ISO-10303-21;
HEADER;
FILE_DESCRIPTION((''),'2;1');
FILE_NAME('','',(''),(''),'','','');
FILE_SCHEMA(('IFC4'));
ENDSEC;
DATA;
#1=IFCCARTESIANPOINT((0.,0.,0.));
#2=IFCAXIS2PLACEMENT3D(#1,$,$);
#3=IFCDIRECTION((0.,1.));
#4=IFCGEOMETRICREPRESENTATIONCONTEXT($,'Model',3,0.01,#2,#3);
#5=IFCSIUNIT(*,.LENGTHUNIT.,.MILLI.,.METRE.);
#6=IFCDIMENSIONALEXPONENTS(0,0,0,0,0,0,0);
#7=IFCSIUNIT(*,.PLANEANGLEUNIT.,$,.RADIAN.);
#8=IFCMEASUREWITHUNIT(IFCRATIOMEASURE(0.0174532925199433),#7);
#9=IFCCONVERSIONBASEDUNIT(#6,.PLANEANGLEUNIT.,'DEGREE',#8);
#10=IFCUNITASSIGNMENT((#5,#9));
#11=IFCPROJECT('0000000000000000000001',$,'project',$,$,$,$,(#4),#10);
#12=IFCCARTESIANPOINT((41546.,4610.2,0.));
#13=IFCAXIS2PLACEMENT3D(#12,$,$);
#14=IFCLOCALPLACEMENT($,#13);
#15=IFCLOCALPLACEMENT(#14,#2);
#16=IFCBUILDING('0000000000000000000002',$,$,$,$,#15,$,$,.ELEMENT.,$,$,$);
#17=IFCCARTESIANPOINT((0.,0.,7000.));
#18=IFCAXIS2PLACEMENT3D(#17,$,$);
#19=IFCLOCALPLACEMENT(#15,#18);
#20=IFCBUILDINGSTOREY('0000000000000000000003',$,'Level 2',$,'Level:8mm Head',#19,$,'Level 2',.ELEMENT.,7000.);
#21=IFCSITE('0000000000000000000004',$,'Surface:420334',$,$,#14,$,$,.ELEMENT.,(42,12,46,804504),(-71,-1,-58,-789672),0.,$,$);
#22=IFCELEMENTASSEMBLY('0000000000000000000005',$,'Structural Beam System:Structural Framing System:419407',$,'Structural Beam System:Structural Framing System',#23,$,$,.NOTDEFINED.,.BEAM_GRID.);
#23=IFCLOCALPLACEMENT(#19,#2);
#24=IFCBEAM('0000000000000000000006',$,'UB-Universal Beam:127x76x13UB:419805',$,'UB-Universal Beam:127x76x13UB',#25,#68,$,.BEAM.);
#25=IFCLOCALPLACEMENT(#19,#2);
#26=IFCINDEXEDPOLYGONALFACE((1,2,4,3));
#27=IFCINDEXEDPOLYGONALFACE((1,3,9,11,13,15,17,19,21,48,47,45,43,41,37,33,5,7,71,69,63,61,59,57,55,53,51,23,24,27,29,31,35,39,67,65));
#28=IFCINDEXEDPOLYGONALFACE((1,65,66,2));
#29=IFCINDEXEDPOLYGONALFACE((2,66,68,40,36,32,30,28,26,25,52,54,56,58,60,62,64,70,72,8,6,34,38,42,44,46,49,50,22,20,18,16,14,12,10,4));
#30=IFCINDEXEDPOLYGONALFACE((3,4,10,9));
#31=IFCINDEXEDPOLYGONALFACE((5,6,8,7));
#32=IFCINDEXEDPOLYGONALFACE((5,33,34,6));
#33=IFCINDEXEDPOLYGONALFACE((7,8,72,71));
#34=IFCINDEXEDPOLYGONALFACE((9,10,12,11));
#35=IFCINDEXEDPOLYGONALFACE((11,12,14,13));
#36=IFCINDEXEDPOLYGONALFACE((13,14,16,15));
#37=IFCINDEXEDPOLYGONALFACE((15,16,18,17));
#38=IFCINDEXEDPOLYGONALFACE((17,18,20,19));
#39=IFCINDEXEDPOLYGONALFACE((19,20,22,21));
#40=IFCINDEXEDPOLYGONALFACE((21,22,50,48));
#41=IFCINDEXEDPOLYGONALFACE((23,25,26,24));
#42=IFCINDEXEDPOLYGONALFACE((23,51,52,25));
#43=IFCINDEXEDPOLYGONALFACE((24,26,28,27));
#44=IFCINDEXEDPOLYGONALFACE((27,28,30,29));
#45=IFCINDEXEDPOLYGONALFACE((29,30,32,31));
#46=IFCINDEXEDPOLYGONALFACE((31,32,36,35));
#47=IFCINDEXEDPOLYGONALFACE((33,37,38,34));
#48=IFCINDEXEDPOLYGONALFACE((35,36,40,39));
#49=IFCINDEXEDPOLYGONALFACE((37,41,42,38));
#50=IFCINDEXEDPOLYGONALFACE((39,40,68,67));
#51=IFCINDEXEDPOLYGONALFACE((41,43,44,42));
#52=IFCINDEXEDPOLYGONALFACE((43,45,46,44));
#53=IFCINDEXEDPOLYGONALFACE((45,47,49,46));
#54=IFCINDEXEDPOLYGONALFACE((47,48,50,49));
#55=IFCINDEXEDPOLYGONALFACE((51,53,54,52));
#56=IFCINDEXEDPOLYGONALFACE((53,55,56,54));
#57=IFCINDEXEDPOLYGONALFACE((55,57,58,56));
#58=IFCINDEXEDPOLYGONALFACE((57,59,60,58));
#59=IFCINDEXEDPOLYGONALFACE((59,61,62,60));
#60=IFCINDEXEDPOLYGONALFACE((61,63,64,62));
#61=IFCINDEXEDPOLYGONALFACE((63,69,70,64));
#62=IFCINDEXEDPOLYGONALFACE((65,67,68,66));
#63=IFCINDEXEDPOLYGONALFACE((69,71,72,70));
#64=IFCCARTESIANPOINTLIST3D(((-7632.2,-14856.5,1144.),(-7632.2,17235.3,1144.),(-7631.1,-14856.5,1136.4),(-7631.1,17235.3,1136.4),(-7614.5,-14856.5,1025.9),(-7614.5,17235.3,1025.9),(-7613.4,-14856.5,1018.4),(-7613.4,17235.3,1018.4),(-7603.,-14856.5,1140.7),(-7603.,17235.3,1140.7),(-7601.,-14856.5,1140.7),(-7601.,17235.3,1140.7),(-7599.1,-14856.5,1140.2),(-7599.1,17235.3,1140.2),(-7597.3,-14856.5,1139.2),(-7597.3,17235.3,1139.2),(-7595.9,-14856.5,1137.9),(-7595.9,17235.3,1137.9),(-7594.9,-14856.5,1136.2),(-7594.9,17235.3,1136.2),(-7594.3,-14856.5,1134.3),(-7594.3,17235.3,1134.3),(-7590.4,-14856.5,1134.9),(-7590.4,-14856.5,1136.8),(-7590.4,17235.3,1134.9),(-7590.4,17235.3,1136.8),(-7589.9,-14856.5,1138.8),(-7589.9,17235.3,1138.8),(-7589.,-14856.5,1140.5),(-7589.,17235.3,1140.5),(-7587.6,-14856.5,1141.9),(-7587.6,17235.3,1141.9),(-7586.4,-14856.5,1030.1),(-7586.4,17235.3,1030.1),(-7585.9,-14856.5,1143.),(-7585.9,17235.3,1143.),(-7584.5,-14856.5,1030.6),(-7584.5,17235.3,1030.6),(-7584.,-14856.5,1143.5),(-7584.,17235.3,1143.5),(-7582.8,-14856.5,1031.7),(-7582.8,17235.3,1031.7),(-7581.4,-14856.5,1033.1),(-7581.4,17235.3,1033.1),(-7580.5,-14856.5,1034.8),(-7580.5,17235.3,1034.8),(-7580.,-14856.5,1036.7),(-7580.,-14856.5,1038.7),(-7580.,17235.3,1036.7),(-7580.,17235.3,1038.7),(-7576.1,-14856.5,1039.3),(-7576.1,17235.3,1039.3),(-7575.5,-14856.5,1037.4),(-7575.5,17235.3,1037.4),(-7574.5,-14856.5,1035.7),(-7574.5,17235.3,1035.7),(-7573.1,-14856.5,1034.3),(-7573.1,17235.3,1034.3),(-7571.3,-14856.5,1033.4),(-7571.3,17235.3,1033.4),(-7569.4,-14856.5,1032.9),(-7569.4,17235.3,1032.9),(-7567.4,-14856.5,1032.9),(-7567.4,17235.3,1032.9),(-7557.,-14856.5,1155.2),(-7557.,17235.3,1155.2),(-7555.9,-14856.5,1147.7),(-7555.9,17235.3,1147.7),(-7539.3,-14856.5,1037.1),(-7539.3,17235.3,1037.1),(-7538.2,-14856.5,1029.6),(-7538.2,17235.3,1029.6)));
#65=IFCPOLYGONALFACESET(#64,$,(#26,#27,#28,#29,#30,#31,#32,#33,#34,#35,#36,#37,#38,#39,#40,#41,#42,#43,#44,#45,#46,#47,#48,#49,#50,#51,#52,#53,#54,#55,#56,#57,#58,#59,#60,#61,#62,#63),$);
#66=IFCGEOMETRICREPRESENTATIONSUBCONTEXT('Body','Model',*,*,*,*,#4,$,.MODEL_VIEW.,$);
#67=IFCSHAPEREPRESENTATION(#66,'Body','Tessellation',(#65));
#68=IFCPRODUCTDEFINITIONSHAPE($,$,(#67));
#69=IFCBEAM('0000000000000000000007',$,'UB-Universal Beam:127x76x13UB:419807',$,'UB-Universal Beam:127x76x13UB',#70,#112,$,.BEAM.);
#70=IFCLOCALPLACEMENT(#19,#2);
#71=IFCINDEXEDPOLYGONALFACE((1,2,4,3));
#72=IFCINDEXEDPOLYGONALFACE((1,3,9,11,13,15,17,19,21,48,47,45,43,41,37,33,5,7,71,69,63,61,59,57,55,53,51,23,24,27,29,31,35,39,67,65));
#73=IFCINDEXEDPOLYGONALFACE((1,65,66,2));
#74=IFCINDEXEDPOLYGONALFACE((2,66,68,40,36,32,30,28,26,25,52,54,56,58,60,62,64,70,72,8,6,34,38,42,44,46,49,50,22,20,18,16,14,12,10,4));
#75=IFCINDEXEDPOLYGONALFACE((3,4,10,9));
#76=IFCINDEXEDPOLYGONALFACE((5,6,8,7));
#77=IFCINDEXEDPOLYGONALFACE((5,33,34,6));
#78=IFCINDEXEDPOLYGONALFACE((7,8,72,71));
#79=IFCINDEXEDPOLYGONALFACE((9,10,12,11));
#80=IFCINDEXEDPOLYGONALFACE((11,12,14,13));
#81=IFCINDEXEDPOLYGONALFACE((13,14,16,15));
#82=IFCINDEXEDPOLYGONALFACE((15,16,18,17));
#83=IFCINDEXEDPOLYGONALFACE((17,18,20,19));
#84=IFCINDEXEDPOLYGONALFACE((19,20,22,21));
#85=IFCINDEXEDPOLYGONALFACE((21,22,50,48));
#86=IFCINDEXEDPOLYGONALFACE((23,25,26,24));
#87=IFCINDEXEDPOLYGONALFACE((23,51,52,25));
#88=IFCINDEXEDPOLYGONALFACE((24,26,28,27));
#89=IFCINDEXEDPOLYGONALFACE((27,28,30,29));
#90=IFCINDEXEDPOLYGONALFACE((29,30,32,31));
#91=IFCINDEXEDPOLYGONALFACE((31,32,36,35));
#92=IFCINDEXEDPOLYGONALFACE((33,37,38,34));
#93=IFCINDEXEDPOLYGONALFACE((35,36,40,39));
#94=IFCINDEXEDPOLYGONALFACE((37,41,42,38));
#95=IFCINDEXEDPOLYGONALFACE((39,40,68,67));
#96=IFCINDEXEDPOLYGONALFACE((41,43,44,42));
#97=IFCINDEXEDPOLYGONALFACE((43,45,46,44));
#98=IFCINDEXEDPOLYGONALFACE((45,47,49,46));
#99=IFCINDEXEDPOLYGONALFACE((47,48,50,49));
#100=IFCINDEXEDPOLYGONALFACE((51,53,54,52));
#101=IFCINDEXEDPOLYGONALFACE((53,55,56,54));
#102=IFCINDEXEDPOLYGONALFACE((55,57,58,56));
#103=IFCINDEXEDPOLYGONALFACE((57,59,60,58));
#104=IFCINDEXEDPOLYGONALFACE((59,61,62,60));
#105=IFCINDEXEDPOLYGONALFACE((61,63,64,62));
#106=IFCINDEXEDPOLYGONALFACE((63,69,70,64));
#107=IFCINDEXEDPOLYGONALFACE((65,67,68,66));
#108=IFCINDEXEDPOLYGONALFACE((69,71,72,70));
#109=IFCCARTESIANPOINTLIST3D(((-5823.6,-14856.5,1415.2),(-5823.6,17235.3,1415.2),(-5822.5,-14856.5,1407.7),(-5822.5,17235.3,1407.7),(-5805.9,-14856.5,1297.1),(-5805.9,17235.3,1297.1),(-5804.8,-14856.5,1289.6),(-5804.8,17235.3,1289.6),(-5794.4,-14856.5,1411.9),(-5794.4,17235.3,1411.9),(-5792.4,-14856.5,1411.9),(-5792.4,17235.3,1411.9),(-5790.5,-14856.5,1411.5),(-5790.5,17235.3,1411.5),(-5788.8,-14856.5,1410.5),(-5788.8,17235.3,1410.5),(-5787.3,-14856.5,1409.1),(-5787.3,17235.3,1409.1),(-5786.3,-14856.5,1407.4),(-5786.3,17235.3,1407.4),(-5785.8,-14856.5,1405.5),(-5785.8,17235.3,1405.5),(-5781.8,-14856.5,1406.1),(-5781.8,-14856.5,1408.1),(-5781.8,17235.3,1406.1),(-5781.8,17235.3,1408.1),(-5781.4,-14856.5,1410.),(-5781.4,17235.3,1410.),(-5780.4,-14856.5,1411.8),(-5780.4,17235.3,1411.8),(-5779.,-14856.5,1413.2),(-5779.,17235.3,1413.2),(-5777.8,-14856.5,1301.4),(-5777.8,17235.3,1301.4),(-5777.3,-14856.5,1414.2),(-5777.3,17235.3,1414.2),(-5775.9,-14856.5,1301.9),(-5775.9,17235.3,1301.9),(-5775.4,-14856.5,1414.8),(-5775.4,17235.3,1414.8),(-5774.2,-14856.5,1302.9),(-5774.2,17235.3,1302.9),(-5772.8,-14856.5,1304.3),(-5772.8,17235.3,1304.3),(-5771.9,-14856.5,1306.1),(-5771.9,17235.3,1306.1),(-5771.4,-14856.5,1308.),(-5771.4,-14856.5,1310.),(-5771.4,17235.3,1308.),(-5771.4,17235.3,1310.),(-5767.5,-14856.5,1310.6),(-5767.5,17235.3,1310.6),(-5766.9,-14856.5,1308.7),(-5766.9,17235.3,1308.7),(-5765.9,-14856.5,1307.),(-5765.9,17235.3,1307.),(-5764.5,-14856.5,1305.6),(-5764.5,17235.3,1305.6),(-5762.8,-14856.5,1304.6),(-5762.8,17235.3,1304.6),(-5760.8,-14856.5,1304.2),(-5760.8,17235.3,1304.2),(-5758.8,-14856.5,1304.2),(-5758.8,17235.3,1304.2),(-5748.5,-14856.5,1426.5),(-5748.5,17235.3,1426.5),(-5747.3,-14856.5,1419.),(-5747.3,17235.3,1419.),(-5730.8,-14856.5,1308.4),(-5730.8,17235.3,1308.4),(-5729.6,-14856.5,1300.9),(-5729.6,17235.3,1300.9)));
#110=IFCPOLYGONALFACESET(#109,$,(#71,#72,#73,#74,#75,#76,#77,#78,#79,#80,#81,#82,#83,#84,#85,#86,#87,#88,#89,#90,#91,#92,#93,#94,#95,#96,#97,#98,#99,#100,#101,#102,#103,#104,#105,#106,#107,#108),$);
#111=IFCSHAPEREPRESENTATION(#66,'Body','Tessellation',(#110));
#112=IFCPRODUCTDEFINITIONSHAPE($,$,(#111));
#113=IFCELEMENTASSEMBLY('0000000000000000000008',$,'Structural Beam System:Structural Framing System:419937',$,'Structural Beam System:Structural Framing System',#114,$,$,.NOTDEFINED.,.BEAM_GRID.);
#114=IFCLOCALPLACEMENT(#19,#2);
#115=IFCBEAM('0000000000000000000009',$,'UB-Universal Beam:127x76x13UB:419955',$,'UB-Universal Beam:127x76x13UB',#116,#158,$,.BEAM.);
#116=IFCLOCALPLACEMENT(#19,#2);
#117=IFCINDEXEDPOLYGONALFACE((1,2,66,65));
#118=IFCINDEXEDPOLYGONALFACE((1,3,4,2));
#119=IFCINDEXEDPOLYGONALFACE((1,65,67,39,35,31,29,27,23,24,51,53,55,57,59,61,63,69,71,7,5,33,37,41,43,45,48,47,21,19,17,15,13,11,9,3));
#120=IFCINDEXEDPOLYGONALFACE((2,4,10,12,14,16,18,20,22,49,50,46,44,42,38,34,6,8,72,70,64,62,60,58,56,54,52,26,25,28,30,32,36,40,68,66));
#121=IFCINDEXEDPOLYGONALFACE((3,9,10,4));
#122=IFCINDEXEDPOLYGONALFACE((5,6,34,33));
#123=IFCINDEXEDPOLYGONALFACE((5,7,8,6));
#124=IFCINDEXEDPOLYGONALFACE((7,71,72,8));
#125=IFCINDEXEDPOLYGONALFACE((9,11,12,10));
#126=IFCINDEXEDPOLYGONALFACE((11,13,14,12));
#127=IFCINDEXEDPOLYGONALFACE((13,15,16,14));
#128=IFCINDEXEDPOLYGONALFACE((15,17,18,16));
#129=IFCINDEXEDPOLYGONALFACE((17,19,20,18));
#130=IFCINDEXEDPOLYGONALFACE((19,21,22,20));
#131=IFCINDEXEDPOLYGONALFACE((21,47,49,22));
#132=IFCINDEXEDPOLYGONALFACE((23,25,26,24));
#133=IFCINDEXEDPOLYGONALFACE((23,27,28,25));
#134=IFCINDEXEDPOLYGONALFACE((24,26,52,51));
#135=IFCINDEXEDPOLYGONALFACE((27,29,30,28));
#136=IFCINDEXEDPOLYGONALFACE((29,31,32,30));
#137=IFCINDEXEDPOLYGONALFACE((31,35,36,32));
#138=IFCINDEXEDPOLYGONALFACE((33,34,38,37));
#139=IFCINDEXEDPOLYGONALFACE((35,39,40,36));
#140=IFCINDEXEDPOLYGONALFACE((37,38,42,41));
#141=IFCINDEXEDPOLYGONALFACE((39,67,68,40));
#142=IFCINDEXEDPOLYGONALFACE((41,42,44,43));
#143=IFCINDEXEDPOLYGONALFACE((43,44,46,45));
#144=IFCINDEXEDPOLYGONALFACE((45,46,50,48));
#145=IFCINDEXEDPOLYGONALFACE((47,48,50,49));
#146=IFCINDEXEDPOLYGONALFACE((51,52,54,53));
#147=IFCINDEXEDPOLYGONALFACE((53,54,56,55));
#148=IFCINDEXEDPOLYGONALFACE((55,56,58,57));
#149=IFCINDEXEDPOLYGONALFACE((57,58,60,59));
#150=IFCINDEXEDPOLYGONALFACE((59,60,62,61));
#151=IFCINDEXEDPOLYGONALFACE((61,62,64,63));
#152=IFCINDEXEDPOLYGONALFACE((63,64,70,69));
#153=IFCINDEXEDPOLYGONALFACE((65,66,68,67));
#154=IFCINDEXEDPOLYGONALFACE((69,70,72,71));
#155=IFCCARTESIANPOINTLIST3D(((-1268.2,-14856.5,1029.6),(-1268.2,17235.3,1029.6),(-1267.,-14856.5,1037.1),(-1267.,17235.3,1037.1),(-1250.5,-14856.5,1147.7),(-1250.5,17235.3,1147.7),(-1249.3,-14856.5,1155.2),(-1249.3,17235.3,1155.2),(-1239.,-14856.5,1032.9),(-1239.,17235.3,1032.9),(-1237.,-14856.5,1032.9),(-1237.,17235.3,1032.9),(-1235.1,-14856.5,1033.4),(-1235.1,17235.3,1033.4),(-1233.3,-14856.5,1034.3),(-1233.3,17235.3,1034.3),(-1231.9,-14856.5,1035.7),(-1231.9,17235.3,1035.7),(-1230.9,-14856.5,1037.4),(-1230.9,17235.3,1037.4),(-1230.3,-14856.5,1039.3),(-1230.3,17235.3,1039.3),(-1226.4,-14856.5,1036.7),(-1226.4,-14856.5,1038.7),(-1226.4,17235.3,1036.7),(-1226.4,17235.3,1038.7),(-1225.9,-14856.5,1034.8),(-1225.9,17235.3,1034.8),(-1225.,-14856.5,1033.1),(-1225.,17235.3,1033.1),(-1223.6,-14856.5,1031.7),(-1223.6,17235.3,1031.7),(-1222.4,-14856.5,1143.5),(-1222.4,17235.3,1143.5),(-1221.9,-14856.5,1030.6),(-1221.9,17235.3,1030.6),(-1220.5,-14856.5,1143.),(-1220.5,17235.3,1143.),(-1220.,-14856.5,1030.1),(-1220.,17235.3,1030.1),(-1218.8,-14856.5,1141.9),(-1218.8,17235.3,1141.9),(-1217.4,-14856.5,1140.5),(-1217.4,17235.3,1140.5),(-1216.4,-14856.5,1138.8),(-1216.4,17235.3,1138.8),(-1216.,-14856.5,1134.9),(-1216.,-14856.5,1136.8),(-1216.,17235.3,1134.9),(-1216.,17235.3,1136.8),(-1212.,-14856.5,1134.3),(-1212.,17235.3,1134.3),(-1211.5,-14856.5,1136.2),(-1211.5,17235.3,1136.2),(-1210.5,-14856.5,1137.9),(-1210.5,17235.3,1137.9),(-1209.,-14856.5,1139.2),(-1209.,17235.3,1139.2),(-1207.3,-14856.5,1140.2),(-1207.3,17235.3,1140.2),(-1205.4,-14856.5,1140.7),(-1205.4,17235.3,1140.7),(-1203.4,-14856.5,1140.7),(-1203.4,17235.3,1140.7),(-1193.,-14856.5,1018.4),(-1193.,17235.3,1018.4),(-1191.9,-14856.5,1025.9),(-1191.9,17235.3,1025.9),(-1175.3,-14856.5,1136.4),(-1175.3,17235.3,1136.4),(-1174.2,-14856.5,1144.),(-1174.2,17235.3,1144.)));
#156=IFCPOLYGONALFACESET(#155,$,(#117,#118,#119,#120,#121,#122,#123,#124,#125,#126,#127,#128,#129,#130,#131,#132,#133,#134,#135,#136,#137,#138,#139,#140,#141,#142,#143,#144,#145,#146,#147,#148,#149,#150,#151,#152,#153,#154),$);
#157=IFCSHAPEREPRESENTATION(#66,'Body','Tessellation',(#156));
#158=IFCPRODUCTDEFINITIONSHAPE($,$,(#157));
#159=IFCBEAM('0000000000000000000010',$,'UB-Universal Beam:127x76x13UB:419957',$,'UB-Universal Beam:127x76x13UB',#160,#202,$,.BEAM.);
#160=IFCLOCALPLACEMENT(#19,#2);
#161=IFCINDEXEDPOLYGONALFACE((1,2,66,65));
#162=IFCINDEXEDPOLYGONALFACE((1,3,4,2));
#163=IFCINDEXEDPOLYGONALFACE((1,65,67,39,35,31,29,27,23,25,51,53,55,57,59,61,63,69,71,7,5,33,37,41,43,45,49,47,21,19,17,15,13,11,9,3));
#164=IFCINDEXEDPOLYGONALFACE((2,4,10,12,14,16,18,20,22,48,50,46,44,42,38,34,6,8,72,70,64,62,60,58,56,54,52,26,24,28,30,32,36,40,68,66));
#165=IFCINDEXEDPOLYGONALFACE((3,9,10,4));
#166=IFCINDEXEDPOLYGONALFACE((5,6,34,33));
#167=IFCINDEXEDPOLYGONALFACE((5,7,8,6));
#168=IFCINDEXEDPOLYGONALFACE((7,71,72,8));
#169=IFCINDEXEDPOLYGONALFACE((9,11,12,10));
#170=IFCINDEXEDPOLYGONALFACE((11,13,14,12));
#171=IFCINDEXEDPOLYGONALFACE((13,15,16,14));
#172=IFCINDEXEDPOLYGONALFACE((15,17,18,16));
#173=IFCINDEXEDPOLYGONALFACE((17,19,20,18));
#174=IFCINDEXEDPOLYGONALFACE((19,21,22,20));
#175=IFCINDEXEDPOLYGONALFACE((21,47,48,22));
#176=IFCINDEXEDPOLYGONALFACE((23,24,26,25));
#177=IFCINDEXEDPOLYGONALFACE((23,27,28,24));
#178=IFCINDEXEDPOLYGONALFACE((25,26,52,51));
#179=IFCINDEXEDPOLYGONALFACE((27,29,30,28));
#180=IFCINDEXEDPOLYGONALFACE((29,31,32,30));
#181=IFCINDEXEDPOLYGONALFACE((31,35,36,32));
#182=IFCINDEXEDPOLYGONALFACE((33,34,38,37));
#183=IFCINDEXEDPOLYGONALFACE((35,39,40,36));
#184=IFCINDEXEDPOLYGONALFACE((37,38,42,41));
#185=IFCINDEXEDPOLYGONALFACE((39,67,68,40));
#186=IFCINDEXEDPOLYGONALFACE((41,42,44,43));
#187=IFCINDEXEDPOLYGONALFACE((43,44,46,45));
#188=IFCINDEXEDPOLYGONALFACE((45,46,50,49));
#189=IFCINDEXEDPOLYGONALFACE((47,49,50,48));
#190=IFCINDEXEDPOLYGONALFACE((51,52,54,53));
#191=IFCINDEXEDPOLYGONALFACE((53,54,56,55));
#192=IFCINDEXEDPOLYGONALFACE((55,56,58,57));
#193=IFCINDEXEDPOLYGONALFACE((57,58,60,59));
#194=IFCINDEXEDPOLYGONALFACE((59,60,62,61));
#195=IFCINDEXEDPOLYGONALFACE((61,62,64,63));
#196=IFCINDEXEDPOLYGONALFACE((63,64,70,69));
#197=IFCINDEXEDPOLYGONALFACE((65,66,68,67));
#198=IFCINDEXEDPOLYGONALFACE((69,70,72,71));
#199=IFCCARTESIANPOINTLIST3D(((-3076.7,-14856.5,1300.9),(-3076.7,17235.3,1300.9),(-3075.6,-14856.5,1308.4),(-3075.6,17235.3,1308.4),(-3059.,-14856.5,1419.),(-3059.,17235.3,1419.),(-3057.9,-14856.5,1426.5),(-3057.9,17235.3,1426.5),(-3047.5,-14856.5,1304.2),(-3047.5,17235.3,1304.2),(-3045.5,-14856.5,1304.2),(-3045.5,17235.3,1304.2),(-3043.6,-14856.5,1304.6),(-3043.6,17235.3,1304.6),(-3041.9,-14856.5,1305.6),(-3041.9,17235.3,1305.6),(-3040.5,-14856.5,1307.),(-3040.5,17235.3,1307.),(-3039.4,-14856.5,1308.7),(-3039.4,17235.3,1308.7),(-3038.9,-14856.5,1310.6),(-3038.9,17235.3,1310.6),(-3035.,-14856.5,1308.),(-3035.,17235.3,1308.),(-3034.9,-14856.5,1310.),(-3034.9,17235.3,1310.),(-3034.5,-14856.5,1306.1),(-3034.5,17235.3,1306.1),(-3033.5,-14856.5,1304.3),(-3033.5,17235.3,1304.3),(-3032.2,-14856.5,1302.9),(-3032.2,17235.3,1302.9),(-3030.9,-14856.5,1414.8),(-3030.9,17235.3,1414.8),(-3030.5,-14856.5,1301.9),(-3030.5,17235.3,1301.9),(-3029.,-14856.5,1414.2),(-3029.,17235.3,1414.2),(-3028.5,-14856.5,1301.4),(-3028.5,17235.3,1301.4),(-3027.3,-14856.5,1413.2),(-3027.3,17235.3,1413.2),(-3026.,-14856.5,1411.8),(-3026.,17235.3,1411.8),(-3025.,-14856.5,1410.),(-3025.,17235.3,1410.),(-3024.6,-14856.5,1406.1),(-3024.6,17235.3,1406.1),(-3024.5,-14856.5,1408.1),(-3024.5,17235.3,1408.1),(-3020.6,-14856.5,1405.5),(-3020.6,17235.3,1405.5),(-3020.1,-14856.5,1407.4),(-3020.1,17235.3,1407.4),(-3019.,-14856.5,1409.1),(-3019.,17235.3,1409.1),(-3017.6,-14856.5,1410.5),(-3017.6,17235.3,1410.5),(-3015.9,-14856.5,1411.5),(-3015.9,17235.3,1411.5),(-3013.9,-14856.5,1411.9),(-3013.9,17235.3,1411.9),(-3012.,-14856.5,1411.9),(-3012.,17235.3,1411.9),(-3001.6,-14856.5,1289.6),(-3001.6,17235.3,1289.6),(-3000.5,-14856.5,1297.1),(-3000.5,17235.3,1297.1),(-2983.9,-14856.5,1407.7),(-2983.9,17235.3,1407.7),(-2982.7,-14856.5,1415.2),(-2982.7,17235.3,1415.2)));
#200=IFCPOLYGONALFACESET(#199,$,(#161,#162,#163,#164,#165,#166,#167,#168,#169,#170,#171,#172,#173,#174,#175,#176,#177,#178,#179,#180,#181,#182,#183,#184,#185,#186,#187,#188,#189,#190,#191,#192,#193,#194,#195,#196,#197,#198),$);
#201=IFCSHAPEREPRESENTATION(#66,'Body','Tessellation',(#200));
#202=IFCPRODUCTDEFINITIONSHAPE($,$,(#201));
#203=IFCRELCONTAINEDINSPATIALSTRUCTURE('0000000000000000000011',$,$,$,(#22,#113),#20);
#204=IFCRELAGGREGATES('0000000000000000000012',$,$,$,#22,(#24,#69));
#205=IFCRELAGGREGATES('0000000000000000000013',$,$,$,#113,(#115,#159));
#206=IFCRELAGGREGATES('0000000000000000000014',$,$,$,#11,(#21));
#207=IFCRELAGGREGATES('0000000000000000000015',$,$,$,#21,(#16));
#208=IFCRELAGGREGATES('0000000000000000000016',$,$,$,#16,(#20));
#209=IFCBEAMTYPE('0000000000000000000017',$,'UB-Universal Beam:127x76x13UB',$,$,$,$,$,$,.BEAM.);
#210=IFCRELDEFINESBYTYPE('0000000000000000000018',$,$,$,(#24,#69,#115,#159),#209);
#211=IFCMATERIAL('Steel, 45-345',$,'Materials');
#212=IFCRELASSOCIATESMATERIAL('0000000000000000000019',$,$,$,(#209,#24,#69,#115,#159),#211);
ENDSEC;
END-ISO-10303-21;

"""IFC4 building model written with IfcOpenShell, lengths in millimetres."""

from ifc_helpers import new_model, entity, si_unit, converted_unit, direction, frame, frame_2d, origin, place, context, subcontext, project, spatial, i_section, extrude, source, transform, mapped, material, material_profile, profile_set, profile_usage, type_object, type_shapes, element, aggregate, save


model = new_model("IFC4")

# Units and contexts
model_context = context("Model", 3, precision=0.01, world=origin(), true_north=direction((0.0, 1.0)))
body_context = subcontext(model_context, "Body", "Model", "MODEL_VIEW")
ifc_project = project(units=[si_unit("LENGTHUNIT", "METRE", prefix="MILLI"), converted_unit("PLANEANGLEUNIT", "DEGREE", entity("IfcRatioMeasure", 0.0174532925199433), si_unit("PLANEANGLEUNIT", "RADIAN"), dimensions=[0, 0, 0, 0, 0, 0, 0])], contexts=[model_context])

# Site, building, storey
site_placement = place(None, frame((41546.0, 4610.2, 0.0)))
site = spatial("IfcSite", under=ifc_project, at=site_placement, Name="Surface:420334", CompositionType="ELEMENT", RefLatitude=(42, 12, 46, 804504), RefLongitude=(-71, -1, -58, -789672), RefElevation=0.0)
building_placement = place(site_placement, origin())
building = spatial("IfcBuilding", under=site, at=building_placement, CompositionType="ELEMENT")
storey_placement = place(building_placement, frame((0.0, 0.0, 7000.0)))
storey = spatial("IfcBuildingStorey", under=building, at=storey_placement, Name="Level 2", ObjectType="Level:8mm Head", LongName="Level 2", CompositionType="ELEMENT", Elevation=7000.0)

# Element assemblies, beams
assembly_1_placement = place(storey_placement, origin())
assembly_1 = element("IfcElementAssembly", 1, at=assembly_1_placement, inside=storey, Name="Structural Beam System:Structural Framing System:419407", ObjectType="Structural Beam System:Structural Framing System", AssemblyPlace="NOTDEFINED", PredefinedType="BEAM_GRID")
ifc_material_1 = material(Name="Steel, 45-345", Category="Materials")
ifc_material_profile = material_profile(ifc_material_1, i_section(OverallWidth=76.0, OverallDepth=127.0, WebThickness=4.0, FlangeThickness=7.6, FilletRadius=7.6, at=frame_2d((0.0, 0.0), x_axis=(0.0, 1.0))), Name="127x76x13UB")
ifc_profile_set = profile_set([ifc_material_profile], Name="127x76x13UB")
ifc_profile_usage_1 = profile_usage(ifc_profile_set, cardinal=8)
beam_type = type_object("IfcBeamType", Name="UB-Universal Beam:127x76x13UB", PredefinedType="BEAM", material=ifc_profile_set)
shared_shape = source(origin(), body_context, "Body", "SweptSolid", [
    extrude(i_section(OverallWidth=76.0, OverallDepth=127.0, WebThickness=4.0, FlangeThickness=7.6, FilletRadius=7.6, at=frame_2d((0.0, 0.0), x_axis=(0.0, 1.0))), frame((-15973.5, 0.0, 0.0), z_axis=(1.0, 0.0, 0.0), x_axis=(0.0, 0.0, -1.0)), (0.0, 0.0, 1.0), 32091.8),
])
type_shapes(beam_type, [shared_shape])
beam_1_placement = place(assembly_1_placement, frame((-7585.2, 1261.8, 1086.8), z_axis=(-0.148327, 0.0, 0.988938), x_axis=(0.0, -1.0, 0.0)))
beam_1 = element("IfcBeam", 2, at=beam_1_placement, type_object=beam_type, material=ifc_profile_usage_1, Name="UB-Universal Beam:127x76x13UB:419805", ObjectType="UB-Universal Beam:127x76x13UB", PredefinedType="BEAM", context=body_context, shape_type="MappedRepresentation", body=[
    mapped(shared_shape, transform((0.0, 0.0, 0.0), scale=1.0)),
])
ifc_profile_usage_2 = profile_usage(ifc_profile_set, cardinal=8)
beam_2_placement = place(assembly_1_placement, frame((-5776.6, 1261.8, 1358.1), z_axis=(-0.148327, 0.0, 0.988938), x_axis=(0.0, -1.0, 0.0)))
beam_2 = element("IfcBeam", 3, at=beam_2_placement, type_object=beam_type, material=ifc_profile_usage_2, Name="UB-Universal Beam:127x76x13UB:419807", ObjectType="UB-Universal Beam:127x76x13UB", PredefinedType="BEAM", context=body_context, shape_type="MappedRepresentation", body=[
    mapped(shared_shape, transform((0.0, 0.0, 0.0), scale=1.0)),
])
aggregate(assembly_1, [beam_1, beam_2])
assembly_2_placement = place(storey_placement, origin())
assembly_2 = element("IfcElementAssembly", 4, at=assembly_2_placement, inside=storey, Name="Structural Beam System:Structural Framing System:419937", ObjectType="Structural Beam System:Structural Framing System", AssemblyPlace="NOTDEFINED", PredefinedType="BEAM_GRID")
ifc_profile_usage_3 = profile_usage(ifc_profile_set, cardinal=8)
beam_3_placement = place(assembly_2_placement, frame((-1221.2, 1261.8, 1086.8), z_axis=(0.148327, 0.0, 0.988938), x_axis=(0.0, -1.0, 0.0)))
beam_3 = element("IfcBeam", 5, at=beam_3_placement, type_object=beam_type, material=ifc_profile_usage_3, Name="UB-Universal Beam:127x76x13UB:419955", ObjectType="UB-Universal Beam:127x76x13UB", PredefinedType="BEAM", context=body_context, shape_type="MappedRepresentation", body=[
    mapped(shared_shape, transform((0.0, 0.0, 0.0), scale=1.0)),
])
ifc_profile_usage_4 = profile_usage(ifc_profile_set, cardinal=8)
beam_4_placement = place(assembly_2_placement, frame((-3029.7, 1261.8, 1358.1), z_axis=(0.148327, 0.0, 0.988938), x_axis=(0.0, -1.0, 0.0)))
beam_4 = element("IfcBeam", 6, at=beam_4_placement, type_object=beam_type, material=ifc_profile_usage_4, Name="UB-Universal Beam:127x76x13UB:419957", ObjectType="UB-Universal Beam:127x76x13UB", PredefinedType="BEAM", context=body_context, shape_type="MappedRepresentation", body=[
    mapped(shared_shape, transform((0.0, 0.0, 0.0), scale=1.0)),
])
aggregate(assembly_2, [beam_3, beam_4])

save(model, "model.ifc")
